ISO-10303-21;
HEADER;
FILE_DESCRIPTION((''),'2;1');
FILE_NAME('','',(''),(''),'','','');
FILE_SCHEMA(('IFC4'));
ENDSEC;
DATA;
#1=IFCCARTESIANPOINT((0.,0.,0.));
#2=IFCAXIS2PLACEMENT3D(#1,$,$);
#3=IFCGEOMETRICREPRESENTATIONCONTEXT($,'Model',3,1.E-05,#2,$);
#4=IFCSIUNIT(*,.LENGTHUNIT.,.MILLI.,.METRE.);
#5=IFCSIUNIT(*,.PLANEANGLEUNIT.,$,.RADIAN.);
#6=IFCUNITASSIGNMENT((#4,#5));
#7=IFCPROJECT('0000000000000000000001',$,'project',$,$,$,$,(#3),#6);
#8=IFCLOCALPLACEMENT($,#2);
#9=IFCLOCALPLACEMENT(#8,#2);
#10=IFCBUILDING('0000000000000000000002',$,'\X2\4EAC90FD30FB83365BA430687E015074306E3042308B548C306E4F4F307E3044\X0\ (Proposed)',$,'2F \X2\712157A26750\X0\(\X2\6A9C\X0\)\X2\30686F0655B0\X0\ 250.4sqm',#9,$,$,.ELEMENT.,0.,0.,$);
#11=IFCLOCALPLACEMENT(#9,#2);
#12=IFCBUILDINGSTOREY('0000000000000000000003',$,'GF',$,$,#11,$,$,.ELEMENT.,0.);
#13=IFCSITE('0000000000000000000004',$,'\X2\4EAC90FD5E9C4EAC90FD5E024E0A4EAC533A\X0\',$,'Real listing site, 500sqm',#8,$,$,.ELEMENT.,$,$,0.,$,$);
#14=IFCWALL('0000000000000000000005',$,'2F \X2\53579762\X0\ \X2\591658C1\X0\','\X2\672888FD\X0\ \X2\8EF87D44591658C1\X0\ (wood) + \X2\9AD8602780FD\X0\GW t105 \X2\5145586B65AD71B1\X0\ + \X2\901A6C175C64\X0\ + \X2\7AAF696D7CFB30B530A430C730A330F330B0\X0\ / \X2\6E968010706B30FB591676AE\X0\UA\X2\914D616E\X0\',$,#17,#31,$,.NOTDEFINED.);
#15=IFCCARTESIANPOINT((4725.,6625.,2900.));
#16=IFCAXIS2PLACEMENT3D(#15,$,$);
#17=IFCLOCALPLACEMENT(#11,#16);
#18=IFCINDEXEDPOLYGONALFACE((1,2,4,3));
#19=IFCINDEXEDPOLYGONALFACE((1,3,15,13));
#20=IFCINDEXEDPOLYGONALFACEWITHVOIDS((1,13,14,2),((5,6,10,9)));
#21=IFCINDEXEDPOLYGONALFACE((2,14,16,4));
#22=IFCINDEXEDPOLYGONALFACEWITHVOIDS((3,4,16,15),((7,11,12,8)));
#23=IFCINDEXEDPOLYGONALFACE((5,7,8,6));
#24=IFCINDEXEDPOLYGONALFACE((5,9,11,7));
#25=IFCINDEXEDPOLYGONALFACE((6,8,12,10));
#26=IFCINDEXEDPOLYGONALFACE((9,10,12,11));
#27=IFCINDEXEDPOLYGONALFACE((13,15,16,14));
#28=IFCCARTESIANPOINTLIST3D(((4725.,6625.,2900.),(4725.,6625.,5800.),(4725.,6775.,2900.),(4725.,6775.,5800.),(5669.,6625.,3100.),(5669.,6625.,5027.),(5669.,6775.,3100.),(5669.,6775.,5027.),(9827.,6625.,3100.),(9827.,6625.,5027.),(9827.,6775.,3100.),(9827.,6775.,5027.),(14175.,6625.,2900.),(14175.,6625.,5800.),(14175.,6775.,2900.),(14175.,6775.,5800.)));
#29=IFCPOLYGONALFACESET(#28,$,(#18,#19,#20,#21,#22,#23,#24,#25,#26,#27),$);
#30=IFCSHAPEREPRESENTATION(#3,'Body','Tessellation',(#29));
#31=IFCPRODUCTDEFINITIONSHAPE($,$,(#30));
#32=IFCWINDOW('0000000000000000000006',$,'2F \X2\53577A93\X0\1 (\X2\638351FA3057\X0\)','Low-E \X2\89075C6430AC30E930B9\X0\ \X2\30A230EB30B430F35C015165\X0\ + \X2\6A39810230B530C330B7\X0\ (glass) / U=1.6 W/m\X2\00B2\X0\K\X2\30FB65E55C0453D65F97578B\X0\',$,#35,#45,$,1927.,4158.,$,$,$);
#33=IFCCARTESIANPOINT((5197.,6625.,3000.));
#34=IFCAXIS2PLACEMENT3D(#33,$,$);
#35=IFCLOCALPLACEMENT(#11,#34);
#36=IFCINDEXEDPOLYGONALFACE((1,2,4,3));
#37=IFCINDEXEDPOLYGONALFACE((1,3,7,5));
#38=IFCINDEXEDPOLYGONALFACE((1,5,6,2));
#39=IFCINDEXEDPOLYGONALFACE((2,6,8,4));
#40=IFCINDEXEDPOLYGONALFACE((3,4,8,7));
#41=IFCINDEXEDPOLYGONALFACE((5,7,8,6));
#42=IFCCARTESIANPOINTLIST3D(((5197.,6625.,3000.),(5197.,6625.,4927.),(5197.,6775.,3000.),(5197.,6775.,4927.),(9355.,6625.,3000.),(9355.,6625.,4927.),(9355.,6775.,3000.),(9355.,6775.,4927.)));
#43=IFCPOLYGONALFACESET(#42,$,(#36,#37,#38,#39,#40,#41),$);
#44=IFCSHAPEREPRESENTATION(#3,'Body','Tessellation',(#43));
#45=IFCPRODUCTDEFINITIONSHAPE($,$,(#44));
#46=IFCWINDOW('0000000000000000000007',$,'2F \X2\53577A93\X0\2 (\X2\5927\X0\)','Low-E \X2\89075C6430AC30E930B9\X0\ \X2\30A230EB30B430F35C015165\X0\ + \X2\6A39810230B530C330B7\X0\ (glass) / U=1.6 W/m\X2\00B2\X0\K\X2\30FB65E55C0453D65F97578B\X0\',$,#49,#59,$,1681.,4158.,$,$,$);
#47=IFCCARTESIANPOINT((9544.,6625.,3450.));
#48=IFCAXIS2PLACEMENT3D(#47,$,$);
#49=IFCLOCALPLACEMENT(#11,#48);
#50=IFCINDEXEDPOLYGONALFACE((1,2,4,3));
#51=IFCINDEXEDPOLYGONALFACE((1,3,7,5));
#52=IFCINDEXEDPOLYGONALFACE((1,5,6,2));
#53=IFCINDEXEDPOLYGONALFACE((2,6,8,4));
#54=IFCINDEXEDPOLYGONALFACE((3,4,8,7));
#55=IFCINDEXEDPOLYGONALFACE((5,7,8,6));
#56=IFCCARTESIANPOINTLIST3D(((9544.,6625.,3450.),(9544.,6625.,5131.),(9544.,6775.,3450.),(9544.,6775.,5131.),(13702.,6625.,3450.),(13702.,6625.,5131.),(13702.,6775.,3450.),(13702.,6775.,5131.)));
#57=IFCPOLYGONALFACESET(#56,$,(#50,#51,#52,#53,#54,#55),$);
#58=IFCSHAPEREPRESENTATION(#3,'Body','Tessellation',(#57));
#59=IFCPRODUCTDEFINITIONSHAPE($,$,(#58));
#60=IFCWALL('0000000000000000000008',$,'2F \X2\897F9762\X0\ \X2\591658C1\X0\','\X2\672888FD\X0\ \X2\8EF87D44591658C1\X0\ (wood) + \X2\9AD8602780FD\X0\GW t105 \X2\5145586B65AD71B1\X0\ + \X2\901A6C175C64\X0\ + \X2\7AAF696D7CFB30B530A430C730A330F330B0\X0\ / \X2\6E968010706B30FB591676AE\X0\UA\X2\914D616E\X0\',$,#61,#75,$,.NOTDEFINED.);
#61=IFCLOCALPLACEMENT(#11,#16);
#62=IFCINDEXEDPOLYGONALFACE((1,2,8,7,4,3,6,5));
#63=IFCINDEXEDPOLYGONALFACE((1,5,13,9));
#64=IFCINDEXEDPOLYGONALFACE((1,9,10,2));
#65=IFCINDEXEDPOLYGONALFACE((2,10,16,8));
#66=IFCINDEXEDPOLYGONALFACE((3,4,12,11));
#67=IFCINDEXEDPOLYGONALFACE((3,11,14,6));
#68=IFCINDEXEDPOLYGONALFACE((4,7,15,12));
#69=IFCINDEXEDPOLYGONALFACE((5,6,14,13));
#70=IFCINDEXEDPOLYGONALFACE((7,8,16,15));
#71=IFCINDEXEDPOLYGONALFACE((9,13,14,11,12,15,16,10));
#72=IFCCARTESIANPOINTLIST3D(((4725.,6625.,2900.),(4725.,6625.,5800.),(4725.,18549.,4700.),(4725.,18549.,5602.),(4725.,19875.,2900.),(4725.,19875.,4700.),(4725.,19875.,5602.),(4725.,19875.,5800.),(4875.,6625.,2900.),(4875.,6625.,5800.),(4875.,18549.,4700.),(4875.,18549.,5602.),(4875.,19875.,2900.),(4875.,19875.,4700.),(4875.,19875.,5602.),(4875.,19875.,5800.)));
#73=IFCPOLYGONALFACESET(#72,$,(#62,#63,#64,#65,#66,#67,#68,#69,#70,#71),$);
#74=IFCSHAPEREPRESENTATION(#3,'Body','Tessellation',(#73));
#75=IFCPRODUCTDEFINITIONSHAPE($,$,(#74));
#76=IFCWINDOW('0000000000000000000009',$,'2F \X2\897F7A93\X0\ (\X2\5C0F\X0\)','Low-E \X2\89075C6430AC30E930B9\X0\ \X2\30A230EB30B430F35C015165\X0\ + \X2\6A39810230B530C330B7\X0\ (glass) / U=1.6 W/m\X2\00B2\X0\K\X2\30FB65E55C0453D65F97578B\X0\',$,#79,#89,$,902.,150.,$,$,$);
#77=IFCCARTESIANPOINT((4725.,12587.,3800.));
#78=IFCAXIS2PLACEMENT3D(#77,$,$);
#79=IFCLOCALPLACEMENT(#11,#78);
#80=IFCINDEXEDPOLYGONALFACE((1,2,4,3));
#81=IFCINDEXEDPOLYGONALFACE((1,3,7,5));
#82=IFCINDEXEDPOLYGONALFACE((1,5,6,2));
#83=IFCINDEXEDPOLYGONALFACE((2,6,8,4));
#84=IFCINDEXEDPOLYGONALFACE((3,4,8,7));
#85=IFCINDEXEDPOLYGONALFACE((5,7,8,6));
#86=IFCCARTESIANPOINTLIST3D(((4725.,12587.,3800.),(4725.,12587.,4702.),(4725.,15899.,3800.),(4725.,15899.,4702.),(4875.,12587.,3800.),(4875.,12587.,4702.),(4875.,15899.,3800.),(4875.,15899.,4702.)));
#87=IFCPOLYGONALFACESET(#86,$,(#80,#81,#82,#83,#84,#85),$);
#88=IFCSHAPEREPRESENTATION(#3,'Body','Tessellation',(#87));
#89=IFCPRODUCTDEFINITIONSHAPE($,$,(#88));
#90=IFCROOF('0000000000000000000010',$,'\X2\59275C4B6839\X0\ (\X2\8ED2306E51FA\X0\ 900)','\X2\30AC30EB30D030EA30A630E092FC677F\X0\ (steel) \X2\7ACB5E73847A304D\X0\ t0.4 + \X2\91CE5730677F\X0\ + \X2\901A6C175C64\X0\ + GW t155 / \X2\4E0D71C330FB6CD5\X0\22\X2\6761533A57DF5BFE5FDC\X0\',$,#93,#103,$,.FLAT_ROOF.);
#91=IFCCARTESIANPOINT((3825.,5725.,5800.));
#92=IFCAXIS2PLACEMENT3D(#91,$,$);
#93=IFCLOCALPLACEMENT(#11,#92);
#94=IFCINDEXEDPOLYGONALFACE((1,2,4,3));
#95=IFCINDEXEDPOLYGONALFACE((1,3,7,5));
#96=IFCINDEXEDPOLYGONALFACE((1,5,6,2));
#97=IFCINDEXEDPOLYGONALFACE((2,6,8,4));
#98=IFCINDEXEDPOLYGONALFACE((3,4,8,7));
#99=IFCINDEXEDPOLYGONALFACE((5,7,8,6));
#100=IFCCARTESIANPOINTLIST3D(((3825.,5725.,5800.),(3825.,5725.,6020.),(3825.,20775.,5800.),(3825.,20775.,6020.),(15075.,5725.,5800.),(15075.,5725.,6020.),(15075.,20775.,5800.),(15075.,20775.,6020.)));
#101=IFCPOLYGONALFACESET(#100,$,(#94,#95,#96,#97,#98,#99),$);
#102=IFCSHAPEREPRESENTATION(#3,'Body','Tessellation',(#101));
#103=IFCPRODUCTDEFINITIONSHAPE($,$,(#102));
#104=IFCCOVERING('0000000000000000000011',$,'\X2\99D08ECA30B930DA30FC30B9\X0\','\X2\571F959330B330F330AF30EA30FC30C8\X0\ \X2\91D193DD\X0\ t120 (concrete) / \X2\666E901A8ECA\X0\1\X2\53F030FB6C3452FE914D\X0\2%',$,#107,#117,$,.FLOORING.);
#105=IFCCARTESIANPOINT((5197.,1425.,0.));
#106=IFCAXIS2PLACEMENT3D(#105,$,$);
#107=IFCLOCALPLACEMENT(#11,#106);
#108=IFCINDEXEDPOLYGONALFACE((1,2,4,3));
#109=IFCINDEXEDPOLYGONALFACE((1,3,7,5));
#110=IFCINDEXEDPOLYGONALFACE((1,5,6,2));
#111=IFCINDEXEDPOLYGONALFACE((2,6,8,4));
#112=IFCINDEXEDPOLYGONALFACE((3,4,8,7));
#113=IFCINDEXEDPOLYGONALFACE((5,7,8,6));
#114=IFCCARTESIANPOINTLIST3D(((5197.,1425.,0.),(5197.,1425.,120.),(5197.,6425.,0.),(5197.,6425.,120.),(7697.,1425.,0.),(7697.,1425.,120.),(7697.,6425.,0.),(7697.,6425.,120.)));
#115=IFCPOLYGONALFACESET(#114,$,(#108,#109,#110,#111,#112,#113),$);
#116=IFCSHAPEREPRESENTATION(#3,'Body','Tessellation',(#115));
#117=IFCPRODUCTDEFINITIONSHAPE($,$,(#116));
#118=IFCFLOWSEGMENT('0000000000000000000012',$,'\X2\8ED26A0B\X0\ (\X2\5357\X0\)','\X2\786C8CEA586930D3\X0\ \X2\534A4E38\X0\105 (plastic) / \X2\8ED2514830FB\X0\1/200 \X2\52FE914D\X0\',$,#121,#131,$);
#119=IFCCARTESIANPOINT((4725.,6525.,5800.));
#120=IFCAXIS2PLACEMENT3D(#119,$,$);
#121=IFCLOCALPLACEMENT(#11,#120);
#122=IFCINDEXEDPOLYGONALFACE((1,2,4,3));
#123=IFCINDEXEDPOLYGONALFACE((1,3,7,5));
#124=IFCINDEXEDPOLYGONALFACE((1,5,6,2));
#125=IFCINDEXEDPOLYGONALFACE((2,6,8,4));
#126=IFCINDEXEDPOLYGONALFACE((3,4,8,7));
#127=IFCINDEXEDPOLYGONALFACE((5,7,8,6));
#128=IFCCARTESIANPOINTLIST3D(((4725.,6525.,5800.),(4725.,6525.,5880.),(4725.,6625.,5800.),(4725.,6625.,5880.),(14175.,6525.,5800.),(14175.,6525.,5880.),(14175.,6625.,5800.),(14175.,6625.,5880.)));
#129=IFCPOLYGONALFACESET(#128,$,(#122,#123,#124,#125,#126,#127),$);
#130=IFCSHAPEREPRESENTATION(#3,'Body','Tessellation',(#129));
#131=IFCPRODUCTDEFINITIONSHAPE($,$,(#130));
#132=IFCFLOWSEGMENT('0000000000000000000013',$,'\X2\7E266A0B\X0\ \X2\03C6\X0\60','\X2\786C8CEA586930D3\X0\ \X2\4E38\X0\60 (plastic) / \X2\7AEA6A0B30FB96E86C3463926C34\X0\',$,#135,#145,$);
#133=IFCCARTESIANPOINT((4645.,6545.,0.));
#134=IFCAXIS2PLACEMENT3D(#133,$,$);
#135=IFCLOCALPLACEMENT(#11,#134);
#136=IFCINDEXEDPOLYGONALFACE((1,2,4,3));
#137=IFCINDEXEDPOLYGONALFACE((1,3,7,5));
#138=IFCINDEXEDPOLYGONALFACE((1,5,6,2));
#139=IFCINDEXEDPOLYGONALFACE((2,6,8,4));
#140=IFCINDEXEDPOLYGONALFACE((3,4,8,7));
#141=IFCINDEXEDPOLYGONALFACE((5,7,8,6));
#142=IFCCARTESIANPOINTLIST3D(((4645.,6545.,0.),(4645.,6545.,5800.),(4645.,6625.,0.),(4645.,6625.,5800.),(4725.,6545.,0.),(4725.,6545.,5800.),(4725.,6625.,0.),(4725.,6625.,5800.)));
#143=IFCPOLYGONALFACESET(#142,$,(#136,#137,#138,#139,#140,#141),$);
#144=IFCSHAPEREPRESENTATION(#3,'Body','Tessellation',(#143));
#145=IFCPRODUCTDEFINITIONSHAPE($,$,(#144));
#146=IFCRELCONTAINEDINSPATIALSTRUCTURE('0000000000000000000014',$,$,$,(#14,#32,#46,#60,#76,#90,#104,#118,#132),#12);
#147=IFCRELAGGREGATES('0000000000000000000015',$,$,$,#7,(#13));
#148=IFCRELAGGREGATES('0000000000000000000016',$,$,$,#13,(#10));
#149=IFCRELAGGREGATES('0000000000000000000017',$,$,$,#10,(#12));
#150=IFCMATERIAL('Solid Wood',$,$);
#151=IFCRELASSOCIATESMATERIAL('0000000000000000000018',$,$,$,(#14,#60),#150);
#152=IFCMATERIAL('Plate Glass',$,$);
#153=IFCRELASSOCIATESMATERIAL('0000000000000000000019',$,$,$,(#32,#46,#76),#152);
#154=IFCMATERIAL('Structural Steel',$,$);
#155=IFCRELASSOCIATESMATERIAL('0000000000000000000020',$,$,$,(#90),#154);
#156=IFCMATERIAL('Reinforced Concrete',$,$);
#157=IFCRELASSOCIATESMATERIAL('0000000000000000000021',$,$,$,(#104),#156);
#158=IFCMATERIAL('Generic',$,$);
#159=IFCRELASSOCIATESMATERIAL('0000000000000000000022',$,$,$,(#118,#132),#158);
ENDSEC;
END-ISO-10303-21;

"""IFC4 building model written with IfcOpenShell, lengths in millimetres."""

from ifc_helpers import new_model, si_unit, frame, frame_2d, origin, place, context, project, spatial, rectangle, extrude, material, element, fill, save


model = new_model("IFC4")

# Units and contexts
model_context = context("Model", 3, precision=1e-05, world=origin())
ifc_project = project(units=[si_unit("LENGTHUNIT", "METRE", prefix="MILLI"), si_unit("PLANEANGLEUNIT", "RADIAN")], contexts=[model_context])

# Site, building, storey
site_placement = place(None, origin())
site = spatial("IfcSite", under=ifc_project, at=site_placement, Name="京都府京都市上京区", ObjectType="Real listing site, 500sqm", CompositionType="ELEMENT", RefElevation=0.0)
building_placement = place(site_placement, origin())
building = spatial("IfcBuilding", under=site, at=building_placement, Name="京都・茶室と縁側のある和の住まい (Proposed)", ObjectType="2F 無垢材(檜)と漆喰 250.4sqm", CompositionType="ELEMENT", ElevationOfRefHeight=0.0, ElevationOfTerrain=0.0)
storey_placement = place(building_placement, origin())
storey = spatial("IfcBuildingStorey", under=building, at=storey_placement, Name="GF", CompositionType="ELEMENT", Elevation=0.0)

# Shared definitions
ifc_material_1 = material(Name="Solid Wood")

# Shared definitions
ifc_material_2 = material(Name="Reinforced Concrete")

# Shared definitions
ifc_material_3 = material(Name="Plate Glass")

# Wall, openings, windows
wall_1_placement = place(storey_placement, frame((4725.0, 6625.0, 2900.0)))
wall_1 = element("IfcWall", 1, at=wall_1_placement, inside=storey, material=ifc_material_1, Name="2F 南面 外壁", Description="木製 軸組外壁 (wood) + 高性能GW t105 充填断熱 + 通気層 + 窯業系サイディング / 準耐火・外皮UA配慮", PredefinedType="NOTDEFINED", context=model_context, shape_type="SweptSolid", body=[
    extrude(rectangle(XDim=9450.0, YDim=150.0, at=frame_2d((4725.0, 75.0))), frame((4725.0, 6625.0, 2900.0)), (0.0, 0.0, 1.0), 2900.0),
])
opening_1_placement = place(storey_placement, frame((5197.0, 6625.0, 3000.0)))
opening_1 = element("IfcOpeningElement", 2, at=opening_1_placement, cuts=wall_1, PredefinedType="NOTDEFINED", context=model_context, shape_type="SweptSolid", body=[
    extrude(rectangle(XDim=4158.0, YDim=150.0, at=frame_2d((2079.0, 75.0))), frame((5197.0, 6625.0, 3000.0)), (0.0, 0.0, 1.0), 1927.0),
])
opening_2_placement = place(storey_placement, frame((9544.0, 6625.0, 3450.0)))
opening_2 = element("IfcOpeningElement", 3, at=opening_2_placement, cuts=wall_1, PredefinedType="NOTDEFINED", context=model_context, shape_type="SweptSolid", body=[
    extrude(rectangle(XDim=4158.0, YDim=150.0, at=frame_2d((2079.0, 75.0))), frame((9544.0, 6625.0, 3450.0)), (0.0, 0.0, 1.0), 1681.0),
])
window_1_placement = place(storey_placement, frame((5197.0, 6625.0, 3000.0)))
window_1 = element("IfcWindow", 4, at=window_1_placement, inside=storey, material=ifc_material_3, Name="2F 南窓1 (掃出し)", Description="Low-E 複層ガラス アルゴン封入 + 樹脂サッシ (glass) / U=1.6 W/m²K・日射取得型", OverallHeight=1927.0, OverallWidth=4158.0, context=model_context, shape_type="SweptSolid", body=[
    extrude(rectangle(XDim=4158.0, YDim=150.0, at=frame_2d((2079.0, 75.0))), frame((5197.0, 6625.0, 3000.0)), (0.0, 0.0, 1.0), 1927.0),
])
fill(opening_1, window_1)
window_2_placement = place(storey_placement, frame((9544.0, 6625.0, 3450.0)))
window_2 = element("IfcWindow", 5, at=window_2_placement, inside=storey, material=ifc_material_3, Name="2F 南窓2 (大)", Description="Low-E 複層ガラス アルゴン封入 + 樹脂サッシ (glass) / U=1.6 W/m²K・日射取得型", OverallHeight=1681.0, OverallWidth=4158.0, context=model_context, shape_type="SweptSolid", body=[
    extrude(rectangle(XDim=4158.0, YDim=150.0, at=frame_2d((2079.0, 75.0))), frame((9544.0, 6625.0, 3450.0)), (0.0, 0.0, 1.0), 1681.0),
])
fill(opening_2, window_2)

# Wall, opening, window
wall_2_placement = place(storey_placement, frame((4725.0, 6625.0, 2900.0)))
wall_2 = element("IfcWall", 6, at=wall_2_placement, inside=storey, material=ifc_material_1, Name="2F 西面 外壁", Description="木製 軸組外壁 (wood) + 高性能GW t105 充填断熱 + 通気層 + 窯業系サイディング / 準耐火・外皮UA配慮", PredefinedType="NOTDEFINED", context=model_context, shape_type="SweptSolid", body=[
    extrude(rectangle(XDim=150.0, YDim=13250.0, at=frame_2d((75.0, 6625.0))), frame((4725.0, 6625.0, 2900.0)), (0.0, 0.0, 1.0), 2900.0),
])
opening_3_placement = place(storey_placement, frame((4725.0, 12587.0, 3800.0)))
opening_3 = element("IfcOpeningElement", 7, at=opening_3_placement, cuts=wall_2, PredefinedType="NOTDEFINED", context=model_context, shape_type="SweptSolid", body=[
    extrude(rectangle(XDim=150.0, YDim=3312.0, at=frame_2d((75.0, 1656.0))), frame((4725.0, 12587.0, 3800.0)), (0.0, 0.0, 1.0), 902.0),
])
window_3_placement = place(storey_placement, frame((4725.0, 12587.0, 3800.0)))
window_3 = element("IfcWindow", 8, at=window_3_placement, inside=storey, material=ifc_material_3, Name="2F 西窓 (小)", Description="Low-E 複層ガラス アルゴン封入 + 樹脂サッシ (glass) / U=1.6 W/m²K・日射取得型", OverallHeight=902.0, OverallWidth=150.0, context=model_context, shape_type="SweptSolid", body=[
    extrude(rectangle(XDim=150.0, YDim=3312.0, at=frame_2d((75.0, 1656.0))), frame((4725.0, 12587.0, 3800.0)), (0.0, 0.0, 1.0), 902.0),
])
fill(opening_3, window_3)

# Roof
ifc_material_4 = material(Name="Structural Steel")
roof_placement = place(storey_placement, frame((3825.0, 5725.0, 5800.0)))
element("IfcRoof", 9, at=roof_placement, inside=storey, material=ifc_material_4, Name="大屋根 (軒の出 900)", Description="ガルバリウム鋼板 (steel) 立平葺き t0.4 + 野地板 + 通気層 + GW t155 / 不燃・法22条区域対応", PredefinedType="FLAT_ROOF", context=model_context, shape_type="SweptSolid", body=[
    extrude(rectangle(XDim=11250.0, YDim=15050.0, at=frame_2d((5625.0, 7525.0))), frame((3825.0, 5725.0, 5800.0)), (0.0, 0.0, 1.0), 220.0),
])

# Covering
covering_placement = place(storey_placement, frame((5197.0, 1425.0, 0.0)))
element("IfcCovering", 10, at=covering_placement, inside=storey, material=ifc_material_2, Name="駐車スペース", Description="土間コンクリート 金鏝 t120 (concrete) / 普通車1台・水勾配2%", PredefinedType="FLOORING", context=model_context, shape_type="SweptSolid", body=[
    extrude(rectangle(XDim=2500.0, YDim=5000.0, at=frame_2d((1250.0, 2500.0))), frame((5197.0, 1425.0, 0.0)), (0.0, 0.0, 1.0), 120.0),
])

# Flow segments
ifc_material_5 = material(Name="Generic")
flow_segment_1_placement = place(storey_placement, frame((4725.0, 6525.0, 5800.0)))
element("IfcFlowSegment", 11, at=flow_segment_1_placement, inside=storey, material=ifc_material_5, Name="軒樋 (南)", Description="硬質塩ビ 半丸105 (plastic) / 軒先・1/200 勾配", context=model_context, shape_type="SweptSolid", body=[
    extrude(rectangle(XDim=9450.0, YDim=100.0, at=frame_2d((4725.0, 50.0))), frame((4725.0, 6525.0, 5800.0)), (0.0, 0.0, 1.0), 80.0),
])
flow_segment_2_placement = place(storey_placement, frame((4645.0, 6545.0, 0.0)))
element("IfcFlowSegment", 12, at=flow_segment_2_placement, inside=storey, material=ifc_material_5, Name="縦樋 φ60", Description="硬質塩ビ 丸60 (plastic) / 竪樋・雨水排水", context=model_context, shape_type="SweptSolid", body=[
    extrude(rectangle(XDim=80.0, YDim=80.0, at=frame_2d((40.0, 40.0))), frame((4645.0, 6545.0, 0.0)), (0.0, 0.0, 1.0), 5800.0),
])

save(model, "model.ifc")
